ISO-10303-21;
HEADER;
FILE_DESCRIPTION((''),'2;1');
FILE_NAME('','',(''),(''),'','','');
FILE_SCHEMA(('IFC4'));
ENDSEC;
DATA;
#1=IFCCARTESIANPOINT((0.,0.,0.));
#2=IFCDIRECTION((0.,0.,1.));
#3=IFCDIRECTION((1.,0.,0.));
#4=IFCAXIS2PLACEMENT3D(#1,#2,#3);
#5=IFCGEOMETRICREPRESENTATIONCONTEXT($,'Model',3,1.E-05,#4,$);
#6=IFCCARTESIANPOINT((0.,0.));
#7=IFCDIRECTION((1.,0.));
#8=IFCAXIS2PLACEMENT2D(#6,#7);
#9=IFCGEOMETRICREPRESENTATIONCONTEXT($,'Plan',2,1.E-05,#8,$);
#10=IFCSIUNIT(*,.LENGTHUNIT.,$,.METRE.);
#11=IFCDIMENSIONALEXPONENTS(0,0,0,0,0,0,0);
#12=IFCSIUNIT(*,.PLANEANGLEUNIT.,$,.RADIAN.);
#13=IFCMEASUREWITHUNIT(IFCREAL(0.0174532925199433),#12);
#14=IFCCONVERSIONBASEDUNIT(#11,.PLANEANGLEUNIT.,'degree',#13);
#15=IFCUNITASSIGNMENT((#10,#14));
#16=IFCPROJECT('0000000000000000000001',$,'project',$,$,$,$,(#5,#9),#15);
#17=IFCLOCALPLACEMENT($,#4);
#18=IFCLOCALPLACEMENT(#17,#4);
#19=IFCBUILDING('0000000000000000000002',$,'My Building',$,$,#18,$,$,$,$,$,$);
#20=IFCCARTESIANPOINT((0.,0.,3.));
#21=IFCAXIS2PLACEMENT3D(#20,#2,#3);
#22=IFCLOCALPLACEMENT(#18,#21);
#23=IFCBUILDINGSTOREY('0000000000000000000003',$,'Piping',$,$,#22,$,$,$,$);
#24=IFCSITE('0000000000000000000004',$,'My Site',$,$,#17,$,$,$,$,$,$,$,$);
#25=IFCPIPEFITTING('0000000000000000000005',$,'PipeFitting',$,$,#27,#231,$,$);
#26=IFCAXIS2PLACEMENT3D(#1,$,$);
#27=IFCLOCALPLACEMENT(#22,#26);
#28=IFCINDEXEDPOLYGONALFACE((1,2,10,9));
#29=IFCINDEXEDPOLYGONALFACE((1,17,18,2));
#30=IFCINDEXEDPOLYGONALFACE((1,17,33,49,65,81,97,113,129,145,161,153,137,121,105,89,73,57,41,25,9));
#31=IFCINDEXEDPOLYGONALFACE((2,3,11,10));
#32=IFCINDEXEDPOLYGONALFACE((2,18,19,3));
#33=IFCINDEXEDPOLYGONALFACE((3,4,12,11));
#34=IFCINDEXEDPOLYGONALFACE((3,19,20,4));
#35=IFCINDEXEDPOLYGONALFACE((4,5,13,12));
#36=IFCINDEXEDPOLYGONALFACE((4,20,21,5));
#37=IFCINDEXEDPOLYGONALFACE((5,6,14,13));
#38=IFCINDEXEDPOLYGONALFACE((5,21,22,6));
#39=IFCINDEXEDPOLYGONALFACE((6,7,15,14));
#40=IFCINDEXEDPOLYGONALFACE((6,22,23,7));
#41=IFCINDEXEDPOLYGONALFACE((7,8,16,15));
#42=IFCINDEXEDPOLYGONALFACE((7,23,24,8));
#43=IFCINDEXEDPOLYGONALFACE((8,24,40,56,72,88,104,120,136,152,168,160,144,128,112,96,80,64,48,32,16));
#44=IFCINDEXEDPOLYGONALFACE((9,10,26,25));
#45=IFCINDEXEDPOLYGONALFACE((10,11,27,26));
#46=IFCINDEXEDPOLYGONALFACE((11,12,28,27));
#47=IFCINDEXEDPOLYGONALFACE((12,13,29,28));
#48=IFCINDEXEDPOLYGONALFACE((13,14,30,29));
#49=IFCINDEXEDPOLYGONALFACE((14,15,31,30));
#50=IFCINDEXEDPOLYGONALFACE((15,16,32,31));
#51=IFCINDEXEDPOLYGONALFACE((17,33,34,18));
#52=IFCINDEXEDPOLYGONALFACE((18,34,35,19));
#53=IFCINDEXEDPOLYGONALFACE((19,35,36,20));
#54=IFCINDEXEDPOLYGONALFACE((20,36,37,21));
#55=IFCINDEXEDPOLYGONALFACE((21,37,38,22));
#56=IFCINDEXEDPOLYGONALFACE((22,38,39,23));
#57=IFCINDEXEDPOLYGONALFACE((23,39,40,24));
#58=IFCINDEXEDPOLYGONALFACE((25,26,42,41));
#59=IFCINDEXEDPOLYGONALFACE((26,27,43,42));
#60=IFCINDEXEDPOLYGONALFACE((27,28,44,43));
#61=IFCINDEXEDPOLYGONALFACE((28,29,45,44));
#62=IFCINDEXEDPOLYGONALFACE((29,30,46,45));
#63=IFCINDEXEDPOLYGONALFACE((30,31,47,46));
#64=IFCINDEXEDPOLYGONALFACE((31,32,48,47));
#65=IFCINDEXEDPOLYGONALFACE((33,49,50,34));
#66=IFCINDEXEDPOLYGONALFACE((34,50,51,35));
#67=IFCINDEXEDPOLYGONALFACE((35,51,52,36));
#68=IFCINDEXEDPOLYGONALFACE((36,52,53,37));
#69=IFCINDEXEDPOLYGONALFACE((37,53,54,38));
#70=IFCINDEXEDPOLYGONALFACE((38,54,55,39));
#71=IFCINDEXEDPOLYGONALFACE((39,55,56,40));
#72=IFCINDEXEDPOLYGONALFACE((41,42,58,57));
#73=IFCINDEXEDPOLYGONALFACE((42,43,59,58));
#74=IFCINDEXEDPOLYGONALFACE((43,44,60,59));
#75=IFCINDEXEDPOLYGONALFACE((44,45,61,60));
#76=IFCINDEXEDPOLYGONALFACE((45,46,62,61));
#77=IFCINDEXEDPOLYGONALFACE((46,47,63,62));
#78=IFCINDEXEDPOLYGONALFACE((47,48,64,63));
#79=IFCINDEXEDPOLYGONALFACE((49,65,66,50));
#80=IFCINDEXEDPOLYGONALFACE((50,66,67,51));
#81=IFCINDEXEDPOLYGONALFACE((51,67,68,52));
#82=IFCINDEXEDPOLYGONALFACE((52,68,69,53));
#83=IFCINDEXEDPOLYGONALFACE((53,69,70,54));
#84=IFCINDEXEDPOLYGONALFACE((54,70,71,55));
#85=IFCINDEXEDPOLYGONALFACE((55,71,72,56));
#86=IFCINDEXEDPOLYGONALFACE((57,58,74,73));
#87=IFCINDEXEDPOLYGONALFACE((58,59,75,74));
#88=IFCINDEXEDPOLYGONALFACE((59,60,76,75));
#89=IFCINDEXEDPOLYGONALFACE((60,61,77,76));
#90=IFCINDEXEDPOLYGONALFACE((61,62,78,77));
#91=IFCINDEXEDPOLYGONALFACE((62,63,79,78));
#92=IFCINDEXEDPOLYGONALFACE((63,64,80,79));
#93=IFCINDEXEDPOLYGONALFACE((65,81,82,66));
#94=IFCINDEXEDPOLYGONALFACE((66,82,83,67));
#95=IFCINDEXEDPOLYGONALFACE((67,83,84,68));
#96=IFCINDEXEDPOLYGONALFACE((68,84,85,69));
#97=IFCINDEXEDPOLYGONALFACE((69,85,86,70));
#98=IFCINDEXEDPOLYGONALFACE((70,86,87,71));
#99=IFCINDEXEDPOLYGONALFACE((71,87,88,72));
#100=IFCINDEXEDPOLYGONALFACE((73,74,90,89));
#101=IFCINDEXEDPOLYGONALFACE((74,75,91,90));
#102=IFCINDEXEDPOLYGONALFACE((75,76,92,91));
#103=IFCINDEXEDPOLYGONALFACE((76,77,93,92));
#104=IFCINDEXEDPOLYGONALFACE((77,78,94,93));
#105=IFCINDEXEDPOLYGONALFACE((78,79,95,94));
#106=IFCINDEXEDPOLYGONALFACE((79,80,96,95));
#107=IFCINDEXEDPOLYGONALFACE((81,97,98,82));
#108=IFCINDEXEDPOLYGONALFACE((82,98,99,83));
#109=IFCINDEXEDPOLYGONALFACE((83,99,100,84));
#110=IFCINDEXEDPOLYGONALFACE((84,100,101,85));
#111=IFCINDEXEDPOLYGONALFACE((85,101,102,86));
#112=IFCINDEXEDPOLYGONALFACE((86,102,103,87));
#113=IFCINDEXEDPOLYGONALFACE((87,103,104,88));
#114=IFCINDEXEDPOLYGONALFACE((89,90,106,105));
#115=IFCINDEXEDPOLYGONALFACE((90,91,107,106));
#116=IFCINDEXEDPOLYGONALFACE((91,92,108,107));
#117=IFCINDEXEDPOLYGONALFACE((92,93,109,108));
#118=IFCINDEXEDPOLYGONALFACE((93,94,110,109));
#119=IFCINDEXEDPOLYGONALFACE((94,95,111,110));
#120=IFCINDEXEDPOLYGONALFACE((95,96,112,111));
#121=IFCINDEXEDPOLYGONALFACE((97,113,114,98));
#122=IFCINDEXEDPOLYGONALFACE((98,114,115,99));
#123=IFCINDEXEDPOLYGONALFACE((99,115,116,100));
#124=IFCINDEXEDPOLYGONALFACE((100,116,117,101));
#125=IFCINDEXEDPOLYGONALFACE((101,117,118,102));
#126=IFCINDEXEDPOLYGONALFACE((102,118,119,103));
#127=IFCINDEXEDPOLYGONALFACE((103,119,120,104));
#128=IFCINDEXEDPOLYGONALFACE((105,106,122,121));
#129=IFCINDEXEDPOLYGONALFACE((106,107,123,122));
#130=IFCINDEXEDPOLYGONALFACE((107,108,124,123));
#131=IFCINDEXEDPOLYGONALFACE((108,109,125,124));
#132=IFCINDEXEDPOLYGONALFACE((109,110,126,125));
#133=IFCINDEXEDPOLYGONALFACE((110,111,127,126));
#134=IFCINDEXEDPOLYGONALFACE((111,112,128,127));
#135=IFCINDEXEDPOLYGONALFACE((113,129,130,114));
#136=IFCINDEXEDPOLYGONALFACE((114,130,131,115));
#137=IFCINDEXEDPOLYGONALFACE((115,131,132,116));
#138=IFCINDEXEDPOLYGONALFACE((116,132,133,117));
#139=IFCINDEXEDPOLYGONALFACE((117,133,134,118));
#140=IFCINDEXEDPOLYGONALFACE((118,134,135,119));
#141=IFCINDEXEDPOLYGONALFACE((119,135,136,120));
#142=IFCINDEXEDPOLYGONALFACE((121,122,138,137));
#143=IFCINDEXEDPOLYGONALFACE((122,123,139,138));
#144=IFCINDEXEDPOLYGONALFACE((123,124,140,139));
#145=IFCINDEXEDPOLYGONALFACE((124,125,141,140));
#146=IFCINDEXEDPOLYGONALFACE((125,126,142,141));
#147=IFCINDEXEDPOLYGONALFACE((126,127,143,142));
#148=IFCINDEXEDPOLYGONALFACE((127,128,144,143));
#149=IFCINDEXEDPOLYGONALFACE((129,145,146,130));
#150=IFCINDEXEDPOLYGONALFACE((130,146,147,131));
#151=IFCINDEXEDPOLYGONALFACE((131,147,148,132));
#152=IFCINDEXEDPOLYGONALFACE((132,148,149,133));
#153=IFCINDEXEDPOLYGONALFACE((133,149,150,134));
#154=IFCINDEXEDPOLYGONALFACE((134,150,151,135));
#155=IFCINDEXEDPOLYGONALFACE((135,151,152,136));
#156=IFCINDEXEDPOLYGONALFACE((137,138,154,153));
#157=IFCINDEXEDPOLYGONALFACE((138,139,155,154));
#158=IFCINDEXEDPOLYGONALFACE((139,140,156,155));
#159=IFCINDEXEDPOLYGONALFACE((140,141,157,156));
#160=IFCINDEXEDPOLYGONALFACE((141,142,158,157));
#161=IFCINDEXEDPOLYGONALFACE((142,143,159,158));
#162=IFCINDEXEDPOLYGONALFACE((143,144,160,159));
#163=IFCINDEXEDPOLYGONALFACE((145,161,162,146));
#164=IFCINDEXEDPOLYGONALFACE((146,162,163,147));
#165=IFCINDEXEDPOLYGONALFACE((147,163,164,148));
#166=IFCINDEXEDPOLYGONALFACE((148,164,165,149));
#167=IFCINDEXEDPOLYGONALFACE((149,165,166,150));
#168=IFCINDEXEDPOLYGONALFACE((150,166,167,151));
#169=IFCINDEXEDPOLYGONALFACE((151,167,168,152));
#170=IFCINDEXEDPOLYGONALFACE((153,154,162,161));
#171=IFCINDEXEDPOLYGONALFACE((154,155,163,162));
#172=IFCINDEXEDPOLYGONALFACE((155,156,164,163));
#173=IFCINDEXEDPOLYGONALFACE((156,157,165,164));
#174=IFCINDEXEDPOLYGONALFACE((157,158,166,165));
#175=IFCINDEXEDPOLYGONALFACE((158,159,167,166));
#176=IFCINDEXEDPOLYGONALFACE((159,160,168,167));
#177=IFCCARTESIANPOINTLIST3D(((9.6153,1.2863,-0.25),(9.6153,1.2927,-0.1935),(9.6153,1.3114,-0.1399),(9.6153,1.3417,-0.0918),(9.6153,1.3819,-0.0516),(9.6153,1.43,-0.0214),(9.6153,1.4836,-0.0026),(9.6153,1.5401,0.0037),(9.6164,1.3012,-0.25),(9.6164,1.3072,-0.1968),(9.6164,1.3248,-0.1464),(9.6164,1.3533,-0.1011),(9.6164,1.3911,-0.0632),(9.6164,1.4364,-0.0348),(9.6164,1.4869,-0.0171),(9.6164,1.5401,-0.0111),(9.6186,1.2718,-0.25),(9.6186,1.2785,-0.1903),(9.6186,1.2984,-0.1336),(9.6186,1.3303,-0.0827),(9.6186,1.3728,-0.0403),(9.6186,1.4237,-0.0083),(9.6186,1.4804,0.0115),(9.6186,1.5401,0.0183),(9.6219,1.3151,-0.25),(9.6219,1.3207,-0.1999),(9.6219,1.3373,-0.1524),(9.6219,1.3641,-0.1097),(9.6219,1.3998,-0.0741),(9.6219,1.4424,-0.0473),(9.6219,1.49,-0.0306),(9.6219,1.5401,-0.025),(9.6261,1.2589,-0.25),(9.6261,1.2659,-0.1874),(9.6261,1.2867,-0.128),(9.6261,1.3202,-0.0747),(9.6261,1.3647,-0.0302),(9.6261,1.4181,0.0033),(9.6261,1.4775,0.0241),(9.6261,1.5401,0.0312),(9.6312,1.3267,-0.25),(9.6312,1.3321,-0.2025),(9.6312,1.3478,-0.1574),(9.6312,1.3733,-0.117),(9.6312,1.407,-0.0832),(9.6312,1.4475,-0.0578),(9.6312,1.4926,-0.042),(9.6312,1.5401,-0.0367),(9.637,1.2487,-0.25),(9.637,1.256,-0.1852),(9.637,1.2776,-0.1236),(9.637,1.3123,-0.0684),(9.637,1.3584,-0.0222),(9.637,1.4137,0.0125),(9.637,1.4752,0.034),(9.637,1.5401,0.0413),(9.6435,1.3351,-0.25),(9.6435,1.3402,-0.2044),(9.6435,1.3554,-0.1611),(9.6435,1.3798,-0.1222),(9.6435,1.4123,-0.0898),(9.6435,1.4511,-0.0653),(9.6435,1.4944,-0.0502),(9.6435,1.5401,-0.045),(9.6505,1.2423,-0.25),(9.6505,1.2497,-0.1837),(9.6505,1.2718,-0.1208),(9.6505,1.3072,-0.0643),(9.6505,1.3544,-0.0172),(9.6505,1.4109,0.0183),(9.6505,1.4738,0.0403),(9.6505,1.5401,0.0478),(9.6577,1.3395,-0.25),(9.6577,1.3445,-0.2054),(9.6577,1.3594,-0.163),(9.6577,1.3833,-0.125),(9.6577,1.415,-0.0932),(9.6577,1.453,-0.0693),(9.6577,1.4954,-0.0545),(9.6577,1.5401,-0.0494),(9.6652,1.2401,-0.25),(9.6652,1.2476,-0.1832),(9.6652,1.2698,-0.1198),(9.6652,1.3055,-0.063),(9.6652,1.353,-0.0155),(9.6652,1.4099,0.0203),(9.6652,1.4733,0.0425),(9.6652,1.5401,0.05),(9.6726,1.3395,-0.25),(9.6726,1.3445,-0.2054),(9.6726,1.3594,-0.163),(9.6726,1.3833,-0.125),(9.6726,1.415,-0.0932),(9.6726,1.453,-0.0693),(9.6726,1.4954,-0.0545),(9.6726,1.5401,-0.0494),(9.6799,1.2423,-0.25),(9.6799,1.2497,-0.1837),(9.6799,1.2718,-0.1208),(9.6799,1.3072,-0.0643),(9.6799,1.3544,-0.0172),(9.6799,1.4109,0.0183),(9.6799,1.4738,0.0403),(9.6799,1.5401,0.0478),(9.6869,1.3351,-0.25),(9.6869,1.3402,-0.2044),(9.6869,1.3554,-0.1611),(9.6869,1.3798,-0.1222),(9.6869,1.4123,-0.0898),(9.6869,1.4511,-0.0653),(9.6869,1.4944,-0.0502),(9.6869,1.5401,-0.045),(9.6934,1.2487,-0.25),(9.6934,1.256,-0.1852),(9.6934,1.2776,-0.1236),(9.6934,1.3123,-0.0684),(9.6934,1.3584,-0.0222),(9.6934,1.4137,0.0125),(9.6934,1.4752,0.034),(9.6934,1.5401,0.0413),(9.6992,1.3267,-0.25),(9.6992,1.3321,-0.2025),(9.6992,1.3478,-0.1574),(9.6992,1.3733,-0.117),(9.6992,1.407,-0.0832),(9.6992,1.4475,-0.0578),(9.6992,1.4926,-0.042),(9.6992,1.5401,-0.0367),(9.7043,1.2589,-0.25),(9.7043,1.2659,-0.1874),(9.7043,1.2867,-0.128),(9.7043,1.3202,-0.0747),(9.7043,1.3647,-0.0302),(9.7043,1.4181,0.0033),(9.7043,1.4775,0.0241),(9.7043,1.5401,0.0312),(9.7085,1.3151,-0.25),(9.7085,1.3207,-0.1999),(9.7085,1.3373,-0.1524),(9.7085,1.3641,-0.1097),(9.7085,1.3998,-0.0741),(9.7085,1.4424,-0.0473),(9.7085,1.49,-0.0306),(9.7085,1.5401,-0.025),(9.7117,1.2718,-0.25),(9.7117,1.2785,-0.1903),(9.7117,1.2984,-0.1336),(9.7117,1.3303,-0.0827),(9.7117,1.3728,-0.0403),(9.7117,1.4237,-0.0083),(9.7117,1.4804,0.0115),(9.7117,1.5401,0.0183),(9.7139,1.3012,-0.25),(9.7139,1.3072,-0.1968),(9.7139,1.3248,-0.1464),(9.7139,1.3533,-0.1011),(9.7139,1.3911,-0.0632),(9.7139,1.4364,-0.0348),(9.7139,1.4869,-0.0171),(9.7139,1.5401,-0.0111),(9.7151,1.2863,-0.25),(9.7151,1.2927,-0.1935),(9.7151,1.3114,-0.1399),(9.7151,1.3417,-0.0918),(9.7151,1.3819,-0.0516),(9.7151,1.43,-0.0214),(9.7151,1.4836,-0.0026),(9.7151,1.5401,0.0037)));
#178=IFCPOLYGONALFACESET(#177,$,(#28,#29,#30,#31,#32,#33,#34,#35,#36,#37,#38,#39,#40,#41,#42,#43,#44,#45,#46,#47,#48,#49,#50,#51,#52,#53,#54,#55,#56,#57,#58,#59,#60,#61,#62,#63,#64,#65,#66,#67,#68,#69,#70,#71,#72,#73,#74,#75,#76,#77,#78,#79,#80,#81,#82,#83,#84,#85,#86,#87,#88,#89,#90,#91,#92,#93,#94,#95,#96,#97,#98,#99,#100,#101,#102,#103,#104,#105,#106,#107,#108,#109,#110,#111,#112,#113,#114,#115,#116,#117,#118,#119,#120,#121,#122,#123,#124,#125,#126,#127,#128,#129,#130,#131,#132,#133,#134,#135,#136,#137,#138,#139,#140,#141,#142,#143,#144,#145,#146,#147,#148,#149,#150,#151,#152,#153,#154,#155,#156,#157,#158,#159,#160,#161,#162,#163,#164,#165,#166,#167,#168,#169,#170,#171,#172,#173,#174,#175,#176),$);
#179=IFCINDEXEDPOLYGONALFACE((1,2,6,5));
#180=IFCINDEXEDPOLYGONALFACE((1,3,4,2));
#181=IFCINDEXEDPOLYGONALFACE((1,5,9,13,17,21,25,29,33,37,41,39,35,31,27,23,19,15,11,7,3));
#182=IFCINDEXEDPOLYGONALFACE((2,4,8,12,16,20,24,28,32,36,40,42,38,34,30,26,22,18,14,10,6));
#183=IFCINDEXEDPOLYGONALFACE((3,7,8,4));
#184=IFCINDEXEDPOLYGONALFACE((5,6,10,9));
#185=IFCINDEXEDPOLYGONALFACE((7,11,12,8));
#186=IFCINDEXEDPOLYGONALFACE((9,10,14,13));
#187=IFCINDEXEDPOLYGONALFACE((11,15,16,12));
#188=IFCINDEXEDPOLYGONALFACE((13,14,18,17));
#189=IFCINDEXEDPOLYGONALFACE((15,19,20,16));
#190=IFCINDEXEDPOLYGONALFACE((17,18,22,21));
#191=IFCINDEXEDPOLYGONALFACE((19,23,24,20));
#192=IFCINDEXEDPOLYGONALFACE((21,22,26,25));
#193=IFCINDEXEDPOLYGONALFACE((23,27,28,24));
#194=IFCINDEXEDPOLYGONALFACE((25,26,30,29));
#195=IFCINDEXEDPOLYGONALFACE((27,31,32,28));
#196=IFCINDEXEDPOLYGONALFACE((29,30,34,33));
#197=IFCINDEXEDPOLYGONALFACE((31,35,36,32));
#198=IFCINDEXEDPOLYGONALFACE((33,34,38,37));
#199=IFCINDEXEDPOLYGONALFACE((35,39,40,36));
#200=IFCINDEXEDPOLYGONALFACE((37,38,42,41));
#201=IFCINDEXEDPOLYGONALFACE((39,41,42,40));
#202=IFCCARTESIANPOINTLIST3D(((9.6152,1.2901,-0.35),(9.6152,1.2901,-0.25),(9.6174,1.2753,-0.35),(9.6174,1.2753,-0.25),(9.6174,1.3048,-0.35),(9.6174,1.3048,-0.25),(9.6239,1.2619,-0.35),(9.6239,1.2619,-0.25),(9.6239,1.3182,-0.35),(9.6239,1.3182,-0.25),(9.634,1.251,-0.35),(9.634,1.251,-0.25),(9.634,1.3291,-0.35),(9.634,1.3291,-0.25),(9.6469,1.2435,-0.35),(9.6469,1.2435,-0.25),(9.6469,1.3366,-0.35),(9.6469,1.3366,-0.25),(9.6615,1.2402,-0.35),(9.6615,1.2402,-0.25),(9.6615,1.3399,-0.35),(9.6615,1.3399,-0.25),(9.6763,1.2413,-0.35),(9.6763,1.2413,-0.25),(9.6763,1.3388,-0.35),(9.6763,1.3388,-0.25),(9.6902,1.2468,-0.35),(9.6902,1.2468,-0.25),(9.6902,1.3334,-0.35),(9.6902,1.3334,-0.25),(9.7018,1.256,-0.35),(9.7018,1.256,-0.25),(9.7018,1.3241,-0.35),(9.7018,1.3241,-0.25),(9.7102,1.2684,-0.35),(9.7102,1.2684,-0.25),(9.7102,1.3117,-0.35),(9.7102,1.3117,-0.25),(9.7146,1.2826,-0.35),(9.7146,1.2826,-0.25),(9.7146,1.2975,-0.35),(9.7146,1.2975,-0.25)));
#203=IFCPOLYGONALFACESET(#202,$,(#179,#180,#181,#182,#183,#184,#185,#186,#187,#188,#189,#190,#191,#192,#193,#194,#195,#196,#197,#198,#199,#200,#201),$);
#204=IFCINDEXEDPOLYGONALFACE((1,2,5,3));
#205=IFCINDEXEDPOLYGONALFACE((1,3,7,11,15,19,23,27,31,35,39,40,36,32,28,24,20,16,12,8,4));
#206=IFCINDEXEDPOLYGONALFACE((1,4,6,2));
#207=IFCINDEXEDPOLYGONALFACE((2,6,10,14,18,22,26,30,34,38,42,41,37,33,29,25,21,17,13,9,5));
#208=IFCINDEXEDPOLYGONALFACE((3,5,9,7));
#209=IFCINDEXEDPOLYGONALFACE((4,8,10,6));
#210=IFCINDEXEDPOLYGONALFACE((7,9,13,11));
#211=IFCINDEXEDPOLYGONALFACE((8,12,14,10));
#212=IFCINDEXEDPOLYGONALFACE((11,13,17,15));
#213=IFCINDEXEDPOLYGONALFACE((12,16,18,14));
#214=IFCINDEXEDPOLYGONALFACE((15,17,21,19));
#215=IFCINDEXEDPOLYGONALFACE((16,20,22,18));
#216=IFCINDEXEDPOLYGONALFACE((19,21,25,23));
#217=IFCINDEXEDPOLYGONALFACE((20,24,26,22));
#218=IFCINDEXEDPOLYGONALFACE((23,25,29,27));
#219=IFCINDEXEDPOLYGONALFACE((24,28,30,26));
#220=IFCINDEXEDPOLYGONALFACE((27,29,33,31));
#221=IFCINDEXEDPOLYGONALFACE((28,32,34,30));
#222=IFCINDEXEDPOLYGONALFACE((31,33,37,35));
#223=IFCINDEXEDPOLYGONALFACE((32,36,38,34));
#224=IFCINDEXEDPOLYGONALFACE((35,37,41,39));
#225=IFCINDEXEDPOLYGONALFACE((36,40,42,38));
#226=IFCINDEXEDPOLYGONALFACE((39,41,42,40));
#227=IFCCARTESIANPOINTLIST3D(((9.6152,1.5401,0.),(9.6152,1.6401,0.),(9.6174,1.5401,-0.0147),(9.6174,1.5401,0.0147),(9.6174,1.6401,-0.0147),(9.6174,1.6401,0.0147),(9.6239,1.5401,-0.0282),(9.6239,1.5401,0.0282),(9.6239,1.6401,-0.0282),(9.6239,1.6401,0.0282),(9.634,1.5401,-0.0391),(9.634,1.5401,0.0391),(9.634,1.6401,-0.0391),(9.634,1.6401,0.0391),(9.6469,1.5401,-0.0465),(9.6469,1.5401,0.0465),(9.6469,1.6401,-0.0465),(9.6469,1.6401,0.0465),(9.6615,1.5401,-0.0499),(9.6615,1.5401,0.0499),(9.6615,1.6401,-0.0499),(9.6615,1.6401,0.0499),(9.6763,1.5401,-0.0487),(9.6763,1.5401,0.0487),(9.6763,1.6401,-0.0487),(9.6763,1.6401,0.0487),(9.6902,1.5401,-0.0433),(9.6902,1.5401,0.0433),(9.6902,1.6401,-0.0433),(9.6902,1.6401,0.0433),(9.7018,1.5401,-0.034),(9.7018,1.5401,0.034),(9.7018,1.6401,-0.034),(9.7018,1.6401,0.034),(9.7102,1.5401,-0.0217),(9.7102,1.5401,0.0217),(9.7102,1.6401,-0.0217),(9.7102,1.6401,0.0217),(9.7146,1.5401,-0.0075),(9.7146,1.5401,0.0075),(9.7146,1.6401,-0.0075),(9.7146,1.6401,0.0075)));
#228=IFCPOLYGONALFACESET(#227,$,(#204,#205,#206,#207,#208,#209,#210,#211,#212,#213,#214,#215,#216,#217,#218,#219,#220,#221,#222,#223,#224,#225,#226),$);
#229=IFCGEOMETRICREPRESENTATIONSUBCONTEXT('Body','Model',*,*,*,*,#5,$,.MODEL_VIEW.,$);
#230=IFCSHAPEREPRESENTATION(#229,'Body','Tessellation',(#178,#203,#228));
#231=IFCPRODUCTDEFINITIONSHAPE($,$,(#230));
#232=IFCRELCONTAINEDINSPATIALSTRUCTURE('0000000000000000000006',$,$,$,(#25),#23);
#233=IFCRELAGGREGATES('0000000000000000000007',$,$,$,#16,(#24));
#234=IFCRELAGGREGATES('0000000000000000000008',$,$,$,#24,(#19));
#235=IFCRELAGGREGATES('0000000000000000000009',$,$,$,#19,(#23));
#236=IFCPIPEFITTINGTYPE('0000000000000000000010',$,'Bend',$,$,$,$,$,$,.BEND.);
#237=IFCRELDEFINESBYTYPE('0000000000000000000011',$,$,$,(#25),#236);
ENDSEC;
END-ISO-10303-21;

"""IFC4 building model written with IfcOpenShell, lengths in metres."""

from ifc_helpers import new_model, entity, si_unit, converted_unit, frame, origin_with_axes, origin_2d_with_axis, place, context, subcontext, project, spatial, circle, extrude, source, transform, mapped, type_object, type_shapes, element, save


model = new_model("IFC4")

# Units and contexts
model_context = context("Model", 3, precision=1e-05, world=origin_with_axes())
plan_context = context("Plan", 2, precision=1e-05, world=origin_2d_with_axis())
body_context = subcontext(model_context, "Body", "Model", "MODEL_VIEW")
ifc_project = project(units=[si_unit("LENGTHUNIT", "METRE"), converted_unit("PLANEANGLEUNIT", "degree", entity("IfcReal", 0.0174532925199433), si_unit("PLANEANGLEUNIT", "RADIAN"), dimensions=[0, 0, 0, 0, 0, 0, 0])], contexts=[model_context, plan_context])

# Site, building, storey
site_placement = place(None, origin_with_axes())
site = spatial("IfcSite", under=ifc_project, at=site_placement, Name="My Site")
building_placement = place(site_placement, origin_with_axes())
building = spatial("IfcBuilding", under=site, at=building_placement, Name="My Building")
storey_placement = place(building_placement, frame((0.0, 0.0, 3.0), z_axis=(0.0, 0.0, 1.0), x_axis=(1.0, 0.0, 0.0)))
storey = spatial("IfcBuildingStorey", under=building, at=storey_placement, Name="Piping")

# Pipe fitting
pipe_fitting_type_1 = type_object("IfcPipeFittingType", Name="Bend", PredefinedType="BEND")
shared_shape = source(origin_with_axes(), body_context, "Body", "SolidModel", [
    entity("IfcSweptDiskSolid", entity("IfcIndexedPolyCurve", entity("IfcCartesianPointList3D", [[0.0, 0.0, -0.1], [0.0, 0.0732, -0.2768], [0.0, 0.25, -0.35]]), [entity("IfcArcIndex", [1, 2, 3])]), 0.05),
    extrude(circle(Radius=0.05), origin_with_axes(), (0.0, 0.0, -1.0), 0.1),
    extrude(circle(Radius=0.05), frame((0.0, 0.25, -0.35), z_axis=(0.0, 1.0, 0.0), x_axis=(1.0, 0.0, 0.0)), (0.0, 0.0, 1.0), 0.1),
])
type_shapes(pipe_fitting_type_1, [shared_shape])
for number, where, z_axis, x_axis, name in (
    (1, (9.6652, 1.2901, -0.35), (0.0, 0.0, -1.0), (-1.0, 0.0, 0.0), "PipeFitting"),
):
    element("IfcPipeFitting", number, at=place(storey_placement, frame(where, z_axis=z_axis, x_axis=x_axis)), inside=storey, type_object=pipe_fitting_type_1, Name=name, context=body_context, shape_type="MappedRepresentation", body=[
        mapped(shared_shape, transform((0.0, 0.0, 0.0), x_axis=(1.0, 0.0, 0.0), y_axis=(0.0, 1.0, 0.0), z_axis=(0.0, 0.0, 1.0), scale=1.0)),
    ])

save(model, "model.ifc")
